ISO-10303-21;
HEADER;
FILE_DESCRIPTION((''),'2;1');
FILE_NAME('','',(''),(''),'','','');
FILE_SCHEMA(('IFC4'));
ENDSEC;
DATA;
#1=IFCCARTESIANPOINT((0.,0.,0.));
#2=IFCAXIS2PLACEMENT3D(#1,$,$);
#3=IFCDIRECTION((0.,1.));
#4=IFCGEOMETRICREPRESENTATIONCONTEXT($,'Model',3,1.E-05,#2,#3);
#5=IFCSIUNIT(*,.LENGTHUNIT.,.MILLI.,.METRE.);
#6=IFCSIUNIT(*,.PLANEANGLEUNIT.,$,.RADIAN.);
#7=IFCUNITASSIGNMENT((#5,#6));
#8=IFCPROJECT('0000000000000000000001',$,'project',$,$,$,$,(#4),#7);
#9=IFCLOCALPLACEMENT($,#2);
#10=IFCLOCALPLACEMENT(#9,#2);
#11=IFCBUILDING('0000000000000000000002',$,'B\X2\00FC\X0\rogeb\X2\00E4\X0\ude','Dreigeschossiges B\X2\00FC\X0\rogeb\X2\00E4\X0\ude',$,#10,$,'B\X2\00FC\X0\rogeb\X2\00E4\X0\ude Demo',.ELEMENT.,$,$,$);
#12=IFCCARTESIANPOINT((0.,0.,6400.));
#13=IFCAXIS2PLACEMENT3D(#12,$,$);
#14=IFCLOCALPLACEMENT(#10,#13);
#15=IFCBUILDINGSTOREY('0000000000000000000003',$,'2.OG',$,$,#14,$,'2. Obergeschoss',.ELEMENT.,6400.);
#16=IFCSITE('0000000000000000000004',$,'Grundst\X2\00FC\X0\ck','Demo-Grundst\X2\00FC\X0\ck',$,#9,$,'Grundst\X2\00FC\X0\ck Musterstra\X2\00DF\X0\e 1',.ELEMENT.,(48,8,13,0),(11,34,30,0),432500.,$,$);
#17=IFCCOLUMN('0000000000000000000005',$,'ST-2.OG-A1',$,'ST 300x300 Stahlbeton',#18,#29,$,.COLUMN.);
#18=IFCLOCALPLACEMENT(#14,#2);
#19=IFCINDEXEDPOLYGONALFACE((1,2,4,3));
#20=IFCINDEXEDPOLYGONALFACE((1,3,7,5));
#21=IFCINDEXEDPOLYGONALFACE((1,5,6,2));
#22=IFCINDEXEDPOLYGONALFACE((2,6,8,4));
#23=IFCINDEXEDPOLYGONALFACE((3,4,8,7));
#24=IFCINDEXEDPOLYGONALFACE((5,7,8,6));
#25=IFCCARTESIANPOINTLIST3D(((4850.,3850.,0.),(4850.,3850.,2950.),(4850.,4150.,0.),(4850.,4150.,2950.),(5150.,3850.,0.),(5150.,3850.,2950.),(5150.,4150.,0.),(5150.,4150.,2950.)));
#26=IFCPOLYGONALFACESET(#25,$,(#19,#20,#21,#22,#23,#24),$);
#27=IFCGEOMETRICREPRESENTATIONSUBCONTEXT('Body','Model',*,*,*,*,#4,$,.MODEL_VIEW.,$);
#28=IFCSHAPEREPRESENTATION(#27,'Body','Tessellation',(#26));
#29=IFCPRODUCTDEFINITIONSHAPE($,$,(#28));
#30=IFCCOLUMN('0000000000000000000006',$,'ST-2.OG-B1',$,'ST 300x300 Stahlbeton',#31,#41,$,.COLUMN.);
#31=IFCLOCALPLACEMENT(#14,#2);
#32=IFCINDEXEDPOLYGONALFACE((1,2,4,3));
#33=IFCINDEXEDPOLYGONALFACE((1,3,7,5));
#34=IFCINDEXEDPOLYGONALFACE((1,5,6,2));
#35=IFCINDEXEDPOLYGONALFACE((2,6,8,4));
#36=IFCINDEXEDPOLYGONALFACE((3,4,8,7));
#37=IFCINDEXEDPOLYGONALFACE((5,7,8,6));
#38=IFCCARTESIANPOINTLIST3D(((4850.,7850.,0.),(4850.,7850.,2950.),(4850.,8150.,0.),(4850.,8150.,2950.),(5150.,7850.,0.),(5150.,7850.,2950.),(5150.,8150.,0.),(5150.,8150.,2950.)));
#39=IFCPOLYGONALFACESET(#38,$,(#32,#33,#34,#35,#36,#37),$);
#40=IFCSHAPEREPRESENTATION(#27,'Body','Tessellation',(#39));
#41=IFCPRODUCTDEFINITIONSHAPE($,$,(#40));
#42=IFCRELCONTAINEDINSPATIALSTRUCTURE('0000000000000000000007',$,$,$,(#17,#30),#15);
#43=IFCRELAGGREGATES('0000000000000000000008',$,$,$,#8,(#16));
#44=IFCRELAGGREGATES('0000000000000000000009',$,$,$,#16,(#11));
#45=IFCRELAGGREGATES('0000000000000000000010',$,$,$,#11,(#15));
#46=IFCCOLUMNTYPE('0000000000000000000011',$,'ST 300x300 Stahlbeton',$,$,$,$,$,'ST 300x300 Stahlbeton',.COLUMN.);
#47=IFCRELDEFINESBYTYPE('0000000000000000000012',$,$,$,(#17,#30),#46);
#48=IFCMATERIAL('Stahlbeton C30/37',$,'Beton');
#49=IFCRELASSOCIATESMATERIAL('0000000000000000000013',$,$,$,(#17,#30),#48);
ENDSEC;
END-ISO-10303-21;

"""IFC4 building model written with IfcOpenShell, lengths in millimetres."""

from ifc_helpers import new_model, si_unit, direction, frame, origin, origin_2d, place, context, subcontext, project, spatial, rectangle, extrude, material, type_object, element, save


model = new_model("IFC4")

# Units and contexts
model_context = context("Model", 3, precision=1e-05, world=origin(), true_north=direction((0.0, 1.0)))
body_context = subcontext(model_context, "Body", "Model", "MODEL_VIEW")
ifc_project = project(units=[si_unit("LENGTHUNIT", "METRE", prefix="MILLI"), si_unit("PLANEANGLEUNIT", "RADIAN")], contexts=[model_context])

# Site, building, storey
site_placement = place(None, origin())
site = spatial("IfcSite", under=ifc_project, at=site_placement, Name="Grundstück", Description="Demo-Grundstück", LongName="Grundstück Musterstraße 1", CompositionType="ELEMENT", RefLatitude=(48, 8, 13, 0), RefLongitude=(11, 34, 30, 0), RefElevation=432500.0)
building_placement = place(site_placement, origin())
building = spatial("IfcBuilding", under=site, at=building_placement, Name="Bürogebäude", Description="Dreigeschossiges Bürogebäude", LongName="Bürogebäude Demo", CompositionType="ELEMENT")
storey_placement = place(building_placement, frame((0.0, 0.0, 6400.0)))
storey = spatial("IfcBuildingStorey", under=building, at=storey_placement, Name="2.OG", LongName="2. Obergeschoss", CompositionType="ELEMENT", Elevation=6400.0)

# Columns
ifc_material_1 = material(Name="Stahlbeton C30/37", Category="Beton")
column_type = type_object("IfcColumnType", Name="ST 300x300 Stahlbeton", ElementType="ST 300x300 Stahlbeton", PredefinedType="COLUMN")
for number, where, name in (
    (1, (5000.0, 4000.0, 0.0), "ST-2.OG-A1"),
    (2, (5000.0, 8000.0, 0.0), "ST-2.OG-B1"),
):
    element("IfcColumn", number, at=place(storey_placement, frame(where)), inside=storey, type_object=column_type, material=ifc_material_1, Name=name, ObjectType="ST 300x300 Stahlbeton", PredefinedType="COLUMN", context=body_context, shape_type="SweptSolid", body=[
        extrude(rectangle(XDim=300.0, YDim=300.0, at=origin_2d()), origin(), (0.0, 0.0, 1.0), 2950.0),
    ])

save(model, "model.ifc")
